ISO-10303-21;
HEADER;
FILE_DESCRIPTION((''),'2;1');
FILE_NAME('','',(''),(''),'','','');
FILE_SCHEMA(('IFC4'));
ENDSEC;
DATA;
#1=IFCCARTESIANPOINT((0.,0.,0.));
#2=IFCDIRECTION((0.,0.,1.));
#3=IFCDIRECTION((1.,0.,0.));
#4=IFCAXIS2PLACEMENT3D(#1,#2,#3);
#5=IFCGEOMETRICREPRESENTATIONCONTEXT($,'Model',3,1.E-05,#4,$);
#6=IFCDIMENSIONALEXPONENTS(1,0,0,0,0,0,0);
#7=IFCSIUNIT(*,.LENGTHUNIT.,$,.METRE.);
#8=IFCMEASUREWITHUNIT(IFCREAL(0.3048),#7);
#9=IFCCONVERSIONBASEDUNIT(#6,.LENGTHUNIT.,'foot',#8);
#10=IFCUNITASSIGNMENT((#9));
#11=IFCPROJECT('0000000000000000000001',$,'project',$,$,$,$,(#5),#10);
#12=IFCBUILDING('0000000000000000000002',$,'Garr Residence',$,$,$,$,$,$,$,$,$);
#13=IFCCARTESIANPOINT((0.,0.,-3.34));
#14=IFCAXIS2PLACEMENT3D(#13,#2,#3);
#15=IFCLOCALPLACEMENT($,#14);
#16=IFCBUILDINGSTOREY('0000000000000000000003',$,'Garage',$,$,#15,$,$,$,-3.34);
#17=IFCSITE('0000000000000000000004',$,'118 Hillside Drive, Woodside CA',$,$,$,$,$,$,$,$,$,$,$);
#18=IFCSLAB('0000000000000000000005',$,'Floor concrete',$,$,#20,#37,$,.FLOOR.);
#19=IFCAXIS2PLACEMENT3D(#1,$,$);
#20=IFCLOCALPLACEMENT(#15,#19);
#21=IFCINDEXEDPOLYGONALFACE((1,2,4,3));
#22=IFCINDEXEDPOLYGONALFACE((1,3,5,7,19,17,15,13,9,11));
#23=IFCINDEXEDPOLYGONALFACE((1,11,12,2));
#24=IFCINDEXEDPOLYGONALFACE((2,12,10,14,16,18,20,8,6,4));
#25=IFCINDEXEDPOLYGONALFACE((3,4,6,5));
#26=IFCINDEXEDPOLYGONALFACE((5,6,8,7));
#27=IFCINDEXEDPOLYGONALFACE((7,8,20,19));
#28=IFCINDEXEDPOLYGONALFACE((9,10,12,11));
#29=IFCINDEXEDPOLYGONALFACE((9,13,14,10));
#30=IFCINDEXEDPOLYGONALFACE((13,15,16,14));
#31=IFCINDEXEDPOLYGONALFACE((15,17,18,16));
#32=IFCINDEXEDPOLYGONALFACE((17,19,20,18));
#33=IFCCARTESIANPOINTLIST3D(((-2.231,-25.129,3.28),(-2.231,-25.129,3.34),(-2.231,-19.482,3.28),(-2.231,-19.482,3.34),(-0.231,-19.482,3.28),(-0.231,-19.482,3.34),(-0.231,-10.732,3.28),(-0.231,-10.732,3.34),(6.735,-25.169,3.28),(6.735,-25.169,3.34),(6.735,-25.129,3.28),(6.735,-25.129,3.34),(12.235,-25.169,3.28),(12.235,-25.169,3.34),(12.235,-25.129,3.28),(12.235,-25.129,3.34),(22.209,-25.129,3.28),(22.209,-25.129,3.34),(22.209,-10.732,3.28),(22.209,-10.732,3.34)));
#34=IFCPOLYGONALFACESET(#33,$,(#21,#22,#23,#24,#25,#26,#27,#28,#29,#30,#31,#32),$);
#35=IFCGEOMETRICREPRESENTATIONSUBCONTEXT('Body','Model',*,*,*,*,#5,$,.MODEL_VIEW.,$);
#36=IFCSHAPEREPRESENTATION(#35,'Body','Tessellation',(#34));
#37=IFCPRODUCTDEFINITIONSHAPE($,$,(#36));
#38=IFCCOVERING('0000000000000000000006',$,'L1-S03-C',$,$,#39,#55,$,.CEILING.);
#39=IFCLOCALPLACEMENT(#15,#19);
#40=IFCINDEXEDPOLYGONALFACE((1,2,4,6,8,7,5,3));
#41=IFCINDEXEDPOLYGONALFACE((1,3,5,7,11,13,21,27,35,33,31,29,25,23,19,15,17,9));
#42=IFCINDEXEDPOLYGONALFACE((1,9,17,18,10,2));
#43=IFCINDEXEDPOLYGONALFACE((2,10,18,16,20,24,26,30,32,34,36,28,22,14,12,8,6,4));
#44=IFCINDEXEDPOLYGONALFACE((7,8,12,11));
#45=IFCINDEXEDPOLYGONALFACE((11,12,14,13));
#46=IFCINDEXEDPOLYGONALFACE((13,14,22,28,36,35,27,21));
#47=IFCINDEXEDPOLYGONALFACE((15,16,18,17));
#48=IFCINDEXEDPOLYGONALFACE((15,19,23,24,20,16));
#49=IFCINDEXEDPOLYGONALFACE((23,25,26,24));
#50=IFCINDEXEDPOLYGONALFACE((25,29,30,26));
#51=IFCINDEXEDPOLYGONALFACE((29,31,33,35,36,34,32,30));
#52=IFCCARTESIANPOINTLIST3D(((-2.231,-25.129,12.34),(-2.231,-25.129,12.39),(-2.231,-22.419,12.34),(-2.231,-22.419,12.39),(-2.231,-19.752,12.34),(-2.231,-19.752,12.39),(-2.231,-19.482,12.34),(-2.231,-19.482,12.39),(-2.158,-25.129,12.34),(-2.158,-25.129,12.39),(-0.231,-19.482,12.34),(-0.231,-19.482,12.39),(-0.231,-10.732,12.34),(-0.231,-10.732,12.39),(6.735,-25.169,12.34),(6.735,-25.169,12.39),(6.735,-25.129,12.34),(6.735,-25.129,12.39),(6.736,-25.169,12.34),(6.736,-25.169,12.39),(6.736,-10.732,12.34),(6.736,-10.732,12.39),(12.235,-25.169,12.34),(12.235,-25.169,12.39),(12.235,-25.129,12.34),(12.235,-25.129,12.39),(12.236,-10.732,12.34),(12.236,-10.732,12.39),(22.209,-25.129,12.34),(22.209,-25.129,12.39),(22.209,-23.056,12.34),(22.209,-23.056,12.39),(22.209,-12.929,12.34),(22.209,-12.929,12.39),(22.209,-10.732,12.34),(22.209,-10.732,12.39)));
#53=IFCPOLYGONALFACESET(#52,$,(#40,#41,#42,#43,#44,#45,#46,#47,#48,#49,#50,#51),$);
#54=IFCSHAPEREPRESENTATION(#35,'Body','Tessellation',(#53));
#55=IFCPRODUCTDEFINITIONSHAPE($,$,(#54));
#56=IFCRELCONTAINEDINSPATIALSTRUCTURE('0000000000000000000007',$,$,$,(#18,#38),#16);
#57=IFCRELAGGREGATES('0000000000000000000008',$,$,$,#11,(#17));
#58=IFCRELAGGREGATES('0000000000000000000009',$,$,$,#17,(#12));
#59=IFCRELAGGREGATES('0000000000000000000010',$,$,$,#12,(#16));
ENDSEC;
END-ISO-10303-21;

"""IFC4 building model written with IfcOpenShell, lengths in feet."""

from ifc_helpers import new_model, entity, si_unit, converted_unit, frame, origin, origin_with_axes, place, context, subcontext, project, spatial, polyline, outline, extrude, element, save


model = new_model("IFC4")

# Units and contexts
model_context = context("Model", 3, precision=1e-05, world=origin_with_axes())
body_context = subcontext(model_context, "Body", "Model", "MODEL_VIEW")
ifc_project = project(units=[converted_unit("LENGTHUNIT", "foot", entity("IfcReal", 0.3048), si_unit("LENGTHUNIT", "METRE"), dimensions=[1, 0, 0, 0, 0, 0, 0])], contexts=[model_context])

# Site, building, storey
site = spatial("IfcSite", under=ifc_project, Name="118 Hillside Drive, Woodside CA")
building = spatial("IfcBuilding", under=site, Name="Garr Residence")
storey_placement = place(None, frame((0.0, 0.0, -3.34), z_axis=(0.0, 0.0, 1.0), x_axis=(1.0, 0.0, 0.0)))
storey = spatial("IfcBuildingStorey", under=building, at=storey_placement, Name="Garage", Elevation=-3.34)

# Slab
slab_placement = place(storey_placement, frame((0.0, 0.0, 3.28), z_axis=(0.0, 0.0, 1.0), x_axis=(1.0, 0.0, 0.0)))
element("IfcSlab", 1, at=slab_placement, inside=storey, Name="Floor concrete", PredefinedType="FLOOR", context=body_context, shape_type="SweptSolid", body=[
    extrude(outline(polyline([(-2.231, -25.129), (-2.231, -19.482), (-0.231, -19.482), (-0.231, -10.732), (22.209, -10.732), (22.209, -25.129), (12.235, -25.129), (12.235, -25.169), (6.735, -25.169), (6.735, -25.129), (-2.231, -25.129)])), origin(), (0.0, 0.0, 1.0), 0.06),
])

# Covering
covering_placement = place(storey_placement, frame((0.0, 0.0, 12.34), z_axis=(0.0, 0.0, 1.0), x_axis=(1.0, 0.0, 0.0)))
element("IfcCovering", 2, at=covering_placement, inside=storey, Name="L1-S03-C", PredefinedType="CEILING", context=body_context, shape_type="SweptSolid", body=[
    extrude(outline(polyline([(-2.231, -22.419), (-2.231, -19.752), (-2.231, -19.482), (-0.231, -19.482), (-0.231, -19.482), (-0.231, -10.732), (6.736, -10.732), (12.236, -10.732), (22.209, -10.732), (22.209, -12.929), (22.209, -23.056), (22.209, -25.129), (12.235, -25.129), (12.235, -25.169), (6.736, -25.169), (6.735, -25.169), (6.735, -25.129), (-2.158, -25.129), (-2.231, -25.129), (-2.231, -22.419)])), origin(), (0.0, 0.0, 1.0), 0.05),
])

save(model, "model.ifc")
